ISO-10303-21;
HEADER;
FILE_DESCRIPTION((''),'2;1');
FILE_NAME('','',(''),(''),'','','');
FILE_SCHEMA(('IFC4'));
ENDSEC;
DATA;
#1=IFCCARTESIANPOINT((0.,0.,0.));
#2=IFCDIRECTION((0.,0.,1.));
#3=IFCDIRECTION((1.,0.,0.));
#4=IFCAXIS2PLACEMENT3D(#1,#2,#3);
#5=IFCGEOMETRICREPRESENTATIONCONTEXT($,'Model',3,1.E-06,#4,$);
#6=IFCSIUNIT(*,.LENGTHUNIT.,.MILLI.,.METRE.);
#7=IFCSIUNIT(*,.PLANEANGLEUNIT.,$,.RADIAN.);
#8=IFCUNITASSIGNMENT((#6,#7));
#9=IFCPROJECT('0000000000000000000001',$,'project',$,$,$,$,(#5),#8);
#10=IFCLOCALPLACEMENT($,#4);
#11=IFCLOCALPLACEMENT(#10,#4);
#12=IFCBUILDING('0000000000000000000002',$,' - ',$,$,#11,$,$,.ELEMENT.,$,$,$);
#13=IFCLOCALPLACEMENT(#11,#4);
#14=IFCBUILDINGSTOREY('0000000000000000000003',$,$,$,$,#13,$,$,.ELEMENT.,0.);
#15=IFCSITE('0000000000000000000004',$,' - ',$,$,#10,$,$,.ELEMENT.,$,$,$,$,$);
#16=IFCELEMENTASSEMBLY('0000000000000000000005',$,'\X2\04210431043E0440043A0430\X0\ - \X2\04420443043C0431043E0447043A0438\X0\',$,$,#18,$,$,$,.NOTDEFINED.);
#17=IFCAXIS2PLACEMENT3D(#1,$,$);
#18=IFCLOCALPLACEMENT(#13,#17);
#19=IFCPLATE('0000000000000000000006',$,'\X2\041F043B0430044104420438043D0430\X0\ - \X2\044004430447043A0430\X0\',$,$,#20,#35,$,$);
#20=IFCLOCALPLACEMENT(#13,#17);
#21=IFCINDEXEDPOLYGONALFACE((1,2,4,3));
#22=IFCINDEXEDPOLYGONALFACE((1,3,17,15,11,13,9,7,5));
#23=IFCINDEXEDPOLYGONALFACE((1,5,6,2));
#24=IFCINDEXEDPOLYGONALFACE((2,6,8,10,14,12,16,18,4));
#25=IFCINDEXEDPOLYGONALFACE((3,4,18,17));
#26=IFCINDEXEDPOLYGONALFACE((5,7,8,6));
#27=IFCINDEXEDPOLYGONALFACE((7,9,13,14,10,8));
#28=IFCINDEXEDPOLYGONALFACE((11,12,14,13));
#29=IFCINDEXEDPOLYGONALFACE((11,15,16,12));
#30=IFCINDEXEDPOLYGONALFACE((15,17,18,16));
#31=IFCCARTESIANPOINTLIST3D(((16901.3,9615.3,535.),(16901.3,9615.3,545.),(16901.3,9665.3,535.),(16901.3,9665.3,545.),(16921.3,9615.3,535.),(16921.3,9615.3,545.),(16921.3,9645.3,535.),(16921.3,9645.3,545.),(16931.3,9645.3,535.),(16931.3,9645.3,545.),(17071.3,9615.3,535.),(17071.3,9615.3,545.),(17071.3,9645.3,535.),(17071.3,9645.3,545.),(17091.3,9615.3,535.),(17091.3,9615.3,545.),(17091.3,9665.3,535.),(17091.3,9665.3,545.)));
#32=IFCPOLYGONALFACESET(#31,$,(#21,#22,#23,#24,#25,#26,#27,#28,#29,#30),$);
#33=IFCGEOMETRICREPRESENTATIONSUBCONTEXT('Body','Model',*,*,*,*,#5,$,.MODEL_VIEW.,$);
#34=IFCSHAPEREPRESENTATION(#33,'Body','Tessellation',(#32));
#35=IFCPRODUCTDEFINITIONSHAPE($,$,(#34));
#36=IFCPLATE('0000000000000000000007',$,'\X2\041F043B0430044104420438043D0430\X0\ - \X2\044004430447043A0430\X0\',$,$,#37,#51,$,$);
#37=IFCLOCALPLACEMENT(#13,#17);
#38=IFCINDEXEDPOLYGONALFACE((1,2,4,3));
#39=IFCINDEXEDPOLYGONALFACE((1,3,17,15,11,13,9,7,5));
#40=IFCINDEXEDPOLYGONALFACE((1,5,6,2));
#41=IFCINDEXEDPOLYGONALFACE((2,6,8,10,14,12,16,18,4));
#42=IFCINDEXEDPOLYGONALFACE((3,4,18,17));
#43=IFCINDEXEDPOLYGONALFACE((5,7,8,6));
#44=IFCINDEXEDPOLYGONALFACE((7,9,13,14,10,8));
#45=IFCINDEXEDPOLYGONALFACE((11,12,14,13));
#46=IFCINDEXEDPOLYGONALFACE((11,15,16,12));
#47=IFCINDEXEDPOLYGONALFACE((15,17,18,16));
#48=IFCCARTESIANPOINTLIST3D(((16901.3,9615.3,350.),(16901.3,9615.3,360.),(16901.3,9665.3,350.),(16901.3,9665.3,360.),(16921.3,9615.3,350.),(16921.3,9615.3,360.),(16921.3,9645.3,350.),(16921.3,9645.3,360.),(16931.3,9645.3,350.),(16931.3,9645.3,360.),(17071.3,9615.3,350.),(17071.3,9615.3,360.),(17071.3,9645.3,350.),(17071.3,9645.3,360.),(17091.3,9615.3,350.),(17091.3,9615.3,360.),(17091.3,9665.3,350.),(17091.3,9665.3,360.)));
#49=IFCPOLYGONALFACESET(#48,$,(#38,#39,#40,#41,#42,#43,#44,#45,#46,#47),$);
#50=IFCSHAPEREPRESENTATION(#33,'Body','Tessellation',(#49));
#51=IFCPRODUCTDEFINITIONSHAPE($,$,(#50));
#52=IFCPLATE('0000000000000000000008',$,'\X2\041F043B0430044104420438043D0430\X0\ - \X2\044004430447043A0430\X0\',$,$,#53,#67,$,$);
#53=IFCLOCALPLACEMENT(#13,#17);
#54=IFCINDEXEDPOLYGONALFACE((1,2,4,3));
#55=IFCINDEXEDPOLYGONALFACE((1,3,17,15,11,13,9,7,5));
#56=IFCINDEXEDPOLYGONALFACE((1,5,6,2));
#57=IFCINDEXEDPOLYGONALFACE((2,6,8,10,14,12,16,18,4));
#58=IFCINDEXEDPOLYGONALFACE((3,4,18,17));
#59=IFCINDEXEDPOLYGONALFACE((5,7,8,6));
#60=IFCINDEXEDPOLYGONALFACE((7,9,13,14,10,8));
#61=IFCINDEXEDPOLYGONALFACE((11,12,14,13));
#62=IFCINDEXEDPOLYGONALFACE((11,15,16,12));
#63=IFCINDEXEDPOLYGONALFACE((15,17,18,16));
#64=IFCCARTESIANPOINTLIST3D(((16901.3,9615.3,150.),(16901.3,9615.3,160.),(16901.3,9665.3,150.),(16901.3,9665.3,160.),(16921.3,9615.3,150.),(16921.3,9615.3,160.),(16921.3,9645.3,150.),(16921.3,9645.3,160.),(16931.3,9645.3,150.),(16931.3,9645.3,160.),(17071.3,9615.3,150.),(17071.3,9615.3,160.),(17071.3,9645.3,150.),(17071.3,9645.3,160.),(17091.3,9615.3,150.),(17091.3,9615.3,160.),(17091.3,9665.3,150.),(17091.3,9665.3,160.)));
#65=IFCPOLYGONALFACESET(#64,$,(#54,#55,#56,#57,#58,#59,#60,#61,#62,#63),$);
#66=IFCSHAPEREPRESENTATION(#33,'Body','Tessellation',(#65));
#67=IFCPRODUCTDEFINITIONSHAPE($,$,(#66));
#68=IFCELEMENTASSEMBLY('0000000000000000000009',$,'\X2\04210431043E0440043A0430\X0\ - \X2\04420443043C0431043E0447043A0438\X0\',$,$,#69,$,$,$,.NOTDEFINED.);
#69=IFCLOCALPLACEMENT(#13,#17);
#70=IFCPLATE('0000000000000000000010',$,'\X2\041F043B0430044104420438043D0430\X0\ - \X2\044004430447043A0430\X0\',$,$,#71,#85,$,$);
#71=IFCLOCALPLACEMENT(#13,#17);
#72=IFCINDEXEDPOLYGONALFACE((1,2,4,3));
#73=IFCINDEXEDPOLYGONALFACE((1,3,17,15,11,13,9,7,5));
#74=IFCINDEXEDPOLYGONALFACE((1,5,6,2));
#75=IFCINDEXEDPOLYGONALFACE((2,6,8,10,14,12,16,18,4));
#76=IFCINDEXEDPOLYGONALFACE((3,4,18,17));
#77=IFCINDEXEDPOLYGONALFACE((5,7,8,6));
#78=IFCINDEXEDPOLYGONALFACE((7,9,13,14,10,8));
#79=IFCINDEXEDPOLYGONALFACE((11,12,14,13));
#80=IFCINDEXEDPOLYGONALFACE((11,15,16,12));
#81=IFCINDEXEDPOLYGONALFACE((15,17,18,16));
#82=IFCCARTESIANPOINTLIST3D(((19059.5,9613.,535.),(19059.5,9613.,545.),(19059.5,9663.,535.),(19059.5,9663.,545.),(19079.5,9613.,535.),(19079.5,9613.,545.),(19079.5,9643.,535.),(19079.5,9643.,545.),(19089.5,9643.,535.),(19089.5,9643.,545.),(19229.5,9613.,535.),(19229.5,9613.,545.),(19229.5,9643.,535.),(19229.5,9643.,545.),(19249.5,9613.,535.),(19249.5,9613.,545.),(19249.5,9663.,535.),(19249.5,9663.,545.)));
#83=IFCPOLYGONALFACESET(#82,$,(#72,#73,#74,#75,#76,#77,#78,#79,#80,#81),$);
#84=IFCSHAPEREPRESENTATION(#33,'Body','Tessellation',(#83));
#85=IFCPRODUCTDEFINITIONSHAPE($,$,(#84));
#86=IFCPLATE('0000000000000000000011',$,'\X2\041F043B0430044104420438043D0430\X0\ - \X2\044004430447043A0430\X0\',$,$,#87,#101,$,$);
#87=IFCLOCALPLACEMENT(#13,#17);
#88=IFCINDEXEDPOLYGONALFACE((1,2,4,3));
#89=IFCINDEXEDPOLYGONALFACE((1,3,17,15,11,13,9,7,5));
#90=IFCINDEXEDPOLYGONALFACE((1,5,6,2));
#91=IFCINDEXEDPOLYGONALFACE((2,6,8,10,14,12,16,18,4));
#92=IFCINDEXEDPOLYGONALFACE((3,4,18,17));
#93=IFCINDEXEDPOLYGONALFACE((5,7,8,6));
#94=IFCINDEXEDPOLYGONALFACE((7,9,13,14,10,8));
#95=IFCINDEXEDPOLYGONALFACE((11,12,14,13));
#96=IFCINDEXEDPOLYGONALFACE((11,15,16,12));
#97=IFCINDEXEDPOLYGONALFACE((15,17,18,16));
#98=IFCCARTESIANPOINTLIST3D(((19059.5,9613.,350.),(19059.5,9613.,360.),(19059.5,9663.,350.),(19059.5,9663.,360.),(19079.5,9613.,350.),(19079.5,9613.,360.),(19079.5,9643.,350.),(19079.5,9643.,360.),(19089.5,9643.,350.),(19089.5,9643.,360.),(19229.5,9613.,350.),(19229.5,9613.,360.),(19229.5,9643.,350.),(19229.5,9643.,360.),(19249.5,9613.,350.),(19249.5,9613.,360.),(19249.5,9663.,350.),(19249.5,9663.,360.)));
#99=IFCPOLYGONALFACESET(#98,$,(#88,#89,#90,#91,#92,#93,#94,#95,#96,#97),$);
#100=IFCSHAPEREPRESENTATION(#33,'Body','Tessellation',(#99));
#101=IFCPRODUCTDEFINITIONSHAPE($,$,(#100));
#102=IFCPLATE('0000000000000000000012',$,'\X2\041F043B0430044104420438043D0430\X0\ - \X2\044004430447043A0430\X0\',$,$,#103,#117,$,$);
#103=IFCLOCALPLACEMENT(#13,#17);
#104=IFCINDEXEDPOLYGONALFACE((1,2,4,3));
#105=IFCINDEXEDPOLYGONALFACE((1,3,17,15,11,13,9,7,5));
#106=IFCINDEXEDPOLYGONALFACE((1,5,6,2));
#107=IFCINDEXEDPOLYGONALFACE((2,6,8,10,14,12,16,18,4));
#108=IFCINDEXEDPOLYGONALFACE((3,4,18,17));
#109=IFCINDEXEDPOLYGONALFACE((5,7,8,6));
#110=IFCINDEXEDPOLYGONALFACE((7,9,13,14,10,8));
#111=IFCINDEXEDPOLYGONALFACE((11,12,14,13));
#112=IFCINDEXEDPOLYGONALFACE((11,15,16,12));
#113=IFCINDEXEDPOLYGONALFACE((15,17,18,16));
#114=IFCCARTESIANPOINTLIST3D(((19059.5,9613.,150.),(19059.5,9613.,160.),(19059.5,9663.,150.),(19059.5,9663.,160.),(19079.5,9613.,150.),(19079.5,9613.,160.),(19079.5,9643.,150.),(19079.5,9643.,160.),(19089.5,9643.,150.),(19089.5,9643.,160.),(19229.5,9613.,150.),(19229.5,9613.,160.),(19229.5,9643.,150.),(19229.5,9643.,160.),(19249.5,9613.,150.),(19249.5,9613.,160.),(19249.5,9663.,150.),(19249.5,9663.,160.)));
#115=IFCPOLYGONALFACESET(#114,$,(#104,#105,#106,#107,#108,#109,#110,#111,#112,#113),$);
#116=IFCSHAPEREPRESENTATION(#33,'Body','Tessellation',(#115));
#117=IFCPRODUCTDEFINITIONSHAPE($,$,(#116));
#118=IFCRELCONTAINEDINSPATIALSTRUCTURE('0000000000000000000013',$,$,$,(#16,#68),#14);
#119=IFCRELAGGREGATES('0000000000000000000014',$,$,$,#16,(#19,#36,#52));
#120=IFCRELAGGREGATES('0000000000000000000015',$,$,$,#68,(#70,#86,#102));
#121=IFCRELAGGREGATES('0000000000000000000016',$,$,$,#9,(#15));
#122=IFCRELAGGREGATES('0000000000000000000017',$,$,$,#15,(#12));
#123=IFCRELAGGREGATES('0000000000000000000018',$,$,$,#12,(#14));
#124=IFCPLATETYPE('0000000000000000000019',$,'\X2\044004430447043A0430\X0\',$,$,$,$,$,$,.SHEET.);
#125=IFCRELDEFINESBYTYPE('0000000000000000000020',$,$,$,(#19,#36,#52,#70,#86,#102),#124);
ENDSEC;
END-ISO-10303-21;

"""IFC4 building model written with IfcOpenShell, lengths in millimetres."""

from ifc_helpers import new_model, si_unit, frame, origin_with_axes, place, context, subcontext, project, spatial, line, indexed_curve, outline, extrude, source, transform, mapped, type_object, element, aggregate, save


model = new_model("IFC4")

# Units and contexts
model_context = context("Model", 3, precision=1e-06, world=origin_with_axes())
body_context = subcontext(model_context, "Body", "Model", "MODEL_VIEW")
ifc_project = project(units=[si_unit("LENGTHUNIT", "METRE", prefix="MILLI"), si_unit("PLANEANGLEUNIT", "RADIAN")], contexts=[model_context])

# Site, building, storey
site_placement = place(None, origin_with_axes())
site = spatial("IfcSite", under=ifc_project, at=site_placement, Name=" - ", CompositionType="ELEMENT")
building_placement = place(site_placement, origin_with_axes())
building = spatial("IfcBuilding", under=site, at=building_placement, Name=" - ", CompositionType="ELEMENT")
storey_placement = place(building_placement, origin_with_axes())
storey = spatial("IfcBuildingStorey", under=building, at=storey_placement, CompositionType="ELEMENT", Elevation=0.0)

# Element assemblies, plates
plate_type_1 = type_object("IfcPlateType", Name="ручка", PredefinedType="SHEET")
shared_shape_1 = source(origin_with_axes(), body_context, "Body", "SweptSolid", [
    extrude(outline(indexed_curve([(-95.0, -25.0), (-75.0, -25.0), (-75.0, 5.0), (-65.0, 5.0), (75.0, 5.0), (75.0, -25.0), (95.0, -25.0), (95.0, 25.0), (-95.0, 25.0)], segments=[line(1, 2), line(2, 3), line(3, 4), line(4, 5), line(5, 6), line(6, 7), line(7, 8), line(8, 9), line(9, 1)])), origin_with_axes(), (0.0, 0.0, 1.0), 10.0),
])
assembly_1_placement = place(storey_placement, frame((17196.3, 9615.3, 0.0), z_axis=(0.0, 0.0, 1.0), x_axis=(-1.0, 0.0, 0.0)))
assembly_1 = element("IfcElementAssembly", 1, at=assembly_1_placement, inside=storey, Name="Сборка - тумбочки", PredefinedType="NOTDEFINED")
plate_1_placement = place(assembly_1_placement, frame((200.0, -25.0, 535.0), z_axis=(0.0, 0.0, 1.0), x_axis=(-1.0, 0.0, 0.0)))
plate_1 = element("IfcPlate", 2, at=plate_1_placement, type_object=plate_type_1, Name="Пластина - ручка", context=body_context, shape_type="MappedRepresentation", body=[
    mapped(shared_shape_1, transform((0.0, 0.0, 0.0), x_axis=(1.0, 0.0, 0.0), y_axis=(0.0, 1.0, 0.0), z_axis=(0.0, 0.0, 1.0), scale=1.0)),
])
plate_2_placement = place(assembly_1_placement, frame((200.0, -25.0, 350.0), z_axis=(0.0, 0.0, 1.0), x_axis=(-1.0, 0.0, 0.0)))
plate_2 = element("IfcPlate", 3, at=plate_2_placement, type_object=plate_type_1, Name="Пластина - ручка", context=body_context, shape_type="MappedRepresentation", body=[
    mapped(shared_shape_1, transform((0.0, 0.0, 0.0), x_axis=(1.0, 0.0, 0.0), y_axis=(0.0, 1.0, 0.0), z_axis=(0.0, 0.0, 1.0), scale=1.0)),
])
plate_3_placement = place(assembly_1_placement, frame((200.0, -25.0, 150.0), z_axis=(0.0, 0.0, 1.0), x_axis=(-1.0, 0.0, 0.0)))
plate_3 = element("IfcPlate", 4, at=plate_3_placement, type_object=plate_type_1, Name="Пластина - ручка", context=body_context, shape_type="MappedRepresentation", body=[
    mapped(shared_shape_1, transform((0.0, 0.0, 0.0), x_axis=(1.0, 0.0, 0.0), y_axis=(0.0, 1.0, 0.0), z_axis=(0.0, 0.0, 1.0), scale=1.0)),
])
aggregate(assembly_1, [plate_1, plate_2, plate_3])
assembly_2_placement = place(storey_placement, frame((19354.5, 9613.0, 0.0), z_axis=(0.0, 0.0, 1.0), x_axis=(-1.0, 0.0, 0.0)))
assembly_2 = element("IfcElementAssembly", 5, at=assembly_2_placement, inside=storey, Name="Сборка - тумбочки", PredefinedType="NOTDEFINED")
plate_4_placement = place(assembly_2_placement, frame((200.0, -25.0, 535.0), z_axis=(0.0, 0.0, 1.0), x_axis=(-1.0, 0.0, 0.0)))
plate_4 = element("IfcPlate", 6, at=plate_4_placement, type_object=plate_type_1, Name="Пластина - ручка", context=body_context, shape_type="MappedRepresentation", body=[
    mapped(shared_shape_1, transform((0.0, 0.0, 0.0), x_axis=(1.0, 0.0, 0.0), y_axis=(0.0, 1.0, 0.0), z_axis=(0.0, 0.0, 1.0), scale=1.0)),
])
plate_5_placement = place(assembly_2_placement, frame((200.0, -25.0, 350.0), z_axis=(0.0, 0.0, 1.0), x_axis=(-1.0, 0.0, 0.0)))
plate_5 = element("IfcPlate", 7, at=plate_5_placement, type_object=plate_type_1, Name="Пластина - ручка", context=body_context, shape_type="MappedRepresentation", body=[
    mapped(shared_shape_1, transform((0.0, 0.0, 0.0), x_axis=(1.0, 0.0, 0.0), y_axis=(0.0, 1.0, 0.0), z_axis=(0.0, 0.0, 1.0), scale=1.0)),
])
plate_6_placement = place(assembly_2_placement, frame((200.0, -25.0, 150.0), z_axis=(0.0, 0.0, 1.0), x_axis=(-1.0, 0.0, 0.0)))
plate_6 = element("IfcPlate", 8, at=plate_6_placement, type_object=plate_type_1, Name="Пластина - ручка", context=body_context, shape_type="MappedRepresentation", body=[
    mapped(shared_shape_1, transform((0.0, 0.0, 0.0), x_axis=(1.0, 0.0, 0.0), y_axis=(0.0, 1.0, 0.0), z_axis=(0.0, 0.0, 1.0), scale=1.0)),
])
aggregate(assembly_2, [plate_4, plate_5, plate_6])

save(model, "model.ifc")
